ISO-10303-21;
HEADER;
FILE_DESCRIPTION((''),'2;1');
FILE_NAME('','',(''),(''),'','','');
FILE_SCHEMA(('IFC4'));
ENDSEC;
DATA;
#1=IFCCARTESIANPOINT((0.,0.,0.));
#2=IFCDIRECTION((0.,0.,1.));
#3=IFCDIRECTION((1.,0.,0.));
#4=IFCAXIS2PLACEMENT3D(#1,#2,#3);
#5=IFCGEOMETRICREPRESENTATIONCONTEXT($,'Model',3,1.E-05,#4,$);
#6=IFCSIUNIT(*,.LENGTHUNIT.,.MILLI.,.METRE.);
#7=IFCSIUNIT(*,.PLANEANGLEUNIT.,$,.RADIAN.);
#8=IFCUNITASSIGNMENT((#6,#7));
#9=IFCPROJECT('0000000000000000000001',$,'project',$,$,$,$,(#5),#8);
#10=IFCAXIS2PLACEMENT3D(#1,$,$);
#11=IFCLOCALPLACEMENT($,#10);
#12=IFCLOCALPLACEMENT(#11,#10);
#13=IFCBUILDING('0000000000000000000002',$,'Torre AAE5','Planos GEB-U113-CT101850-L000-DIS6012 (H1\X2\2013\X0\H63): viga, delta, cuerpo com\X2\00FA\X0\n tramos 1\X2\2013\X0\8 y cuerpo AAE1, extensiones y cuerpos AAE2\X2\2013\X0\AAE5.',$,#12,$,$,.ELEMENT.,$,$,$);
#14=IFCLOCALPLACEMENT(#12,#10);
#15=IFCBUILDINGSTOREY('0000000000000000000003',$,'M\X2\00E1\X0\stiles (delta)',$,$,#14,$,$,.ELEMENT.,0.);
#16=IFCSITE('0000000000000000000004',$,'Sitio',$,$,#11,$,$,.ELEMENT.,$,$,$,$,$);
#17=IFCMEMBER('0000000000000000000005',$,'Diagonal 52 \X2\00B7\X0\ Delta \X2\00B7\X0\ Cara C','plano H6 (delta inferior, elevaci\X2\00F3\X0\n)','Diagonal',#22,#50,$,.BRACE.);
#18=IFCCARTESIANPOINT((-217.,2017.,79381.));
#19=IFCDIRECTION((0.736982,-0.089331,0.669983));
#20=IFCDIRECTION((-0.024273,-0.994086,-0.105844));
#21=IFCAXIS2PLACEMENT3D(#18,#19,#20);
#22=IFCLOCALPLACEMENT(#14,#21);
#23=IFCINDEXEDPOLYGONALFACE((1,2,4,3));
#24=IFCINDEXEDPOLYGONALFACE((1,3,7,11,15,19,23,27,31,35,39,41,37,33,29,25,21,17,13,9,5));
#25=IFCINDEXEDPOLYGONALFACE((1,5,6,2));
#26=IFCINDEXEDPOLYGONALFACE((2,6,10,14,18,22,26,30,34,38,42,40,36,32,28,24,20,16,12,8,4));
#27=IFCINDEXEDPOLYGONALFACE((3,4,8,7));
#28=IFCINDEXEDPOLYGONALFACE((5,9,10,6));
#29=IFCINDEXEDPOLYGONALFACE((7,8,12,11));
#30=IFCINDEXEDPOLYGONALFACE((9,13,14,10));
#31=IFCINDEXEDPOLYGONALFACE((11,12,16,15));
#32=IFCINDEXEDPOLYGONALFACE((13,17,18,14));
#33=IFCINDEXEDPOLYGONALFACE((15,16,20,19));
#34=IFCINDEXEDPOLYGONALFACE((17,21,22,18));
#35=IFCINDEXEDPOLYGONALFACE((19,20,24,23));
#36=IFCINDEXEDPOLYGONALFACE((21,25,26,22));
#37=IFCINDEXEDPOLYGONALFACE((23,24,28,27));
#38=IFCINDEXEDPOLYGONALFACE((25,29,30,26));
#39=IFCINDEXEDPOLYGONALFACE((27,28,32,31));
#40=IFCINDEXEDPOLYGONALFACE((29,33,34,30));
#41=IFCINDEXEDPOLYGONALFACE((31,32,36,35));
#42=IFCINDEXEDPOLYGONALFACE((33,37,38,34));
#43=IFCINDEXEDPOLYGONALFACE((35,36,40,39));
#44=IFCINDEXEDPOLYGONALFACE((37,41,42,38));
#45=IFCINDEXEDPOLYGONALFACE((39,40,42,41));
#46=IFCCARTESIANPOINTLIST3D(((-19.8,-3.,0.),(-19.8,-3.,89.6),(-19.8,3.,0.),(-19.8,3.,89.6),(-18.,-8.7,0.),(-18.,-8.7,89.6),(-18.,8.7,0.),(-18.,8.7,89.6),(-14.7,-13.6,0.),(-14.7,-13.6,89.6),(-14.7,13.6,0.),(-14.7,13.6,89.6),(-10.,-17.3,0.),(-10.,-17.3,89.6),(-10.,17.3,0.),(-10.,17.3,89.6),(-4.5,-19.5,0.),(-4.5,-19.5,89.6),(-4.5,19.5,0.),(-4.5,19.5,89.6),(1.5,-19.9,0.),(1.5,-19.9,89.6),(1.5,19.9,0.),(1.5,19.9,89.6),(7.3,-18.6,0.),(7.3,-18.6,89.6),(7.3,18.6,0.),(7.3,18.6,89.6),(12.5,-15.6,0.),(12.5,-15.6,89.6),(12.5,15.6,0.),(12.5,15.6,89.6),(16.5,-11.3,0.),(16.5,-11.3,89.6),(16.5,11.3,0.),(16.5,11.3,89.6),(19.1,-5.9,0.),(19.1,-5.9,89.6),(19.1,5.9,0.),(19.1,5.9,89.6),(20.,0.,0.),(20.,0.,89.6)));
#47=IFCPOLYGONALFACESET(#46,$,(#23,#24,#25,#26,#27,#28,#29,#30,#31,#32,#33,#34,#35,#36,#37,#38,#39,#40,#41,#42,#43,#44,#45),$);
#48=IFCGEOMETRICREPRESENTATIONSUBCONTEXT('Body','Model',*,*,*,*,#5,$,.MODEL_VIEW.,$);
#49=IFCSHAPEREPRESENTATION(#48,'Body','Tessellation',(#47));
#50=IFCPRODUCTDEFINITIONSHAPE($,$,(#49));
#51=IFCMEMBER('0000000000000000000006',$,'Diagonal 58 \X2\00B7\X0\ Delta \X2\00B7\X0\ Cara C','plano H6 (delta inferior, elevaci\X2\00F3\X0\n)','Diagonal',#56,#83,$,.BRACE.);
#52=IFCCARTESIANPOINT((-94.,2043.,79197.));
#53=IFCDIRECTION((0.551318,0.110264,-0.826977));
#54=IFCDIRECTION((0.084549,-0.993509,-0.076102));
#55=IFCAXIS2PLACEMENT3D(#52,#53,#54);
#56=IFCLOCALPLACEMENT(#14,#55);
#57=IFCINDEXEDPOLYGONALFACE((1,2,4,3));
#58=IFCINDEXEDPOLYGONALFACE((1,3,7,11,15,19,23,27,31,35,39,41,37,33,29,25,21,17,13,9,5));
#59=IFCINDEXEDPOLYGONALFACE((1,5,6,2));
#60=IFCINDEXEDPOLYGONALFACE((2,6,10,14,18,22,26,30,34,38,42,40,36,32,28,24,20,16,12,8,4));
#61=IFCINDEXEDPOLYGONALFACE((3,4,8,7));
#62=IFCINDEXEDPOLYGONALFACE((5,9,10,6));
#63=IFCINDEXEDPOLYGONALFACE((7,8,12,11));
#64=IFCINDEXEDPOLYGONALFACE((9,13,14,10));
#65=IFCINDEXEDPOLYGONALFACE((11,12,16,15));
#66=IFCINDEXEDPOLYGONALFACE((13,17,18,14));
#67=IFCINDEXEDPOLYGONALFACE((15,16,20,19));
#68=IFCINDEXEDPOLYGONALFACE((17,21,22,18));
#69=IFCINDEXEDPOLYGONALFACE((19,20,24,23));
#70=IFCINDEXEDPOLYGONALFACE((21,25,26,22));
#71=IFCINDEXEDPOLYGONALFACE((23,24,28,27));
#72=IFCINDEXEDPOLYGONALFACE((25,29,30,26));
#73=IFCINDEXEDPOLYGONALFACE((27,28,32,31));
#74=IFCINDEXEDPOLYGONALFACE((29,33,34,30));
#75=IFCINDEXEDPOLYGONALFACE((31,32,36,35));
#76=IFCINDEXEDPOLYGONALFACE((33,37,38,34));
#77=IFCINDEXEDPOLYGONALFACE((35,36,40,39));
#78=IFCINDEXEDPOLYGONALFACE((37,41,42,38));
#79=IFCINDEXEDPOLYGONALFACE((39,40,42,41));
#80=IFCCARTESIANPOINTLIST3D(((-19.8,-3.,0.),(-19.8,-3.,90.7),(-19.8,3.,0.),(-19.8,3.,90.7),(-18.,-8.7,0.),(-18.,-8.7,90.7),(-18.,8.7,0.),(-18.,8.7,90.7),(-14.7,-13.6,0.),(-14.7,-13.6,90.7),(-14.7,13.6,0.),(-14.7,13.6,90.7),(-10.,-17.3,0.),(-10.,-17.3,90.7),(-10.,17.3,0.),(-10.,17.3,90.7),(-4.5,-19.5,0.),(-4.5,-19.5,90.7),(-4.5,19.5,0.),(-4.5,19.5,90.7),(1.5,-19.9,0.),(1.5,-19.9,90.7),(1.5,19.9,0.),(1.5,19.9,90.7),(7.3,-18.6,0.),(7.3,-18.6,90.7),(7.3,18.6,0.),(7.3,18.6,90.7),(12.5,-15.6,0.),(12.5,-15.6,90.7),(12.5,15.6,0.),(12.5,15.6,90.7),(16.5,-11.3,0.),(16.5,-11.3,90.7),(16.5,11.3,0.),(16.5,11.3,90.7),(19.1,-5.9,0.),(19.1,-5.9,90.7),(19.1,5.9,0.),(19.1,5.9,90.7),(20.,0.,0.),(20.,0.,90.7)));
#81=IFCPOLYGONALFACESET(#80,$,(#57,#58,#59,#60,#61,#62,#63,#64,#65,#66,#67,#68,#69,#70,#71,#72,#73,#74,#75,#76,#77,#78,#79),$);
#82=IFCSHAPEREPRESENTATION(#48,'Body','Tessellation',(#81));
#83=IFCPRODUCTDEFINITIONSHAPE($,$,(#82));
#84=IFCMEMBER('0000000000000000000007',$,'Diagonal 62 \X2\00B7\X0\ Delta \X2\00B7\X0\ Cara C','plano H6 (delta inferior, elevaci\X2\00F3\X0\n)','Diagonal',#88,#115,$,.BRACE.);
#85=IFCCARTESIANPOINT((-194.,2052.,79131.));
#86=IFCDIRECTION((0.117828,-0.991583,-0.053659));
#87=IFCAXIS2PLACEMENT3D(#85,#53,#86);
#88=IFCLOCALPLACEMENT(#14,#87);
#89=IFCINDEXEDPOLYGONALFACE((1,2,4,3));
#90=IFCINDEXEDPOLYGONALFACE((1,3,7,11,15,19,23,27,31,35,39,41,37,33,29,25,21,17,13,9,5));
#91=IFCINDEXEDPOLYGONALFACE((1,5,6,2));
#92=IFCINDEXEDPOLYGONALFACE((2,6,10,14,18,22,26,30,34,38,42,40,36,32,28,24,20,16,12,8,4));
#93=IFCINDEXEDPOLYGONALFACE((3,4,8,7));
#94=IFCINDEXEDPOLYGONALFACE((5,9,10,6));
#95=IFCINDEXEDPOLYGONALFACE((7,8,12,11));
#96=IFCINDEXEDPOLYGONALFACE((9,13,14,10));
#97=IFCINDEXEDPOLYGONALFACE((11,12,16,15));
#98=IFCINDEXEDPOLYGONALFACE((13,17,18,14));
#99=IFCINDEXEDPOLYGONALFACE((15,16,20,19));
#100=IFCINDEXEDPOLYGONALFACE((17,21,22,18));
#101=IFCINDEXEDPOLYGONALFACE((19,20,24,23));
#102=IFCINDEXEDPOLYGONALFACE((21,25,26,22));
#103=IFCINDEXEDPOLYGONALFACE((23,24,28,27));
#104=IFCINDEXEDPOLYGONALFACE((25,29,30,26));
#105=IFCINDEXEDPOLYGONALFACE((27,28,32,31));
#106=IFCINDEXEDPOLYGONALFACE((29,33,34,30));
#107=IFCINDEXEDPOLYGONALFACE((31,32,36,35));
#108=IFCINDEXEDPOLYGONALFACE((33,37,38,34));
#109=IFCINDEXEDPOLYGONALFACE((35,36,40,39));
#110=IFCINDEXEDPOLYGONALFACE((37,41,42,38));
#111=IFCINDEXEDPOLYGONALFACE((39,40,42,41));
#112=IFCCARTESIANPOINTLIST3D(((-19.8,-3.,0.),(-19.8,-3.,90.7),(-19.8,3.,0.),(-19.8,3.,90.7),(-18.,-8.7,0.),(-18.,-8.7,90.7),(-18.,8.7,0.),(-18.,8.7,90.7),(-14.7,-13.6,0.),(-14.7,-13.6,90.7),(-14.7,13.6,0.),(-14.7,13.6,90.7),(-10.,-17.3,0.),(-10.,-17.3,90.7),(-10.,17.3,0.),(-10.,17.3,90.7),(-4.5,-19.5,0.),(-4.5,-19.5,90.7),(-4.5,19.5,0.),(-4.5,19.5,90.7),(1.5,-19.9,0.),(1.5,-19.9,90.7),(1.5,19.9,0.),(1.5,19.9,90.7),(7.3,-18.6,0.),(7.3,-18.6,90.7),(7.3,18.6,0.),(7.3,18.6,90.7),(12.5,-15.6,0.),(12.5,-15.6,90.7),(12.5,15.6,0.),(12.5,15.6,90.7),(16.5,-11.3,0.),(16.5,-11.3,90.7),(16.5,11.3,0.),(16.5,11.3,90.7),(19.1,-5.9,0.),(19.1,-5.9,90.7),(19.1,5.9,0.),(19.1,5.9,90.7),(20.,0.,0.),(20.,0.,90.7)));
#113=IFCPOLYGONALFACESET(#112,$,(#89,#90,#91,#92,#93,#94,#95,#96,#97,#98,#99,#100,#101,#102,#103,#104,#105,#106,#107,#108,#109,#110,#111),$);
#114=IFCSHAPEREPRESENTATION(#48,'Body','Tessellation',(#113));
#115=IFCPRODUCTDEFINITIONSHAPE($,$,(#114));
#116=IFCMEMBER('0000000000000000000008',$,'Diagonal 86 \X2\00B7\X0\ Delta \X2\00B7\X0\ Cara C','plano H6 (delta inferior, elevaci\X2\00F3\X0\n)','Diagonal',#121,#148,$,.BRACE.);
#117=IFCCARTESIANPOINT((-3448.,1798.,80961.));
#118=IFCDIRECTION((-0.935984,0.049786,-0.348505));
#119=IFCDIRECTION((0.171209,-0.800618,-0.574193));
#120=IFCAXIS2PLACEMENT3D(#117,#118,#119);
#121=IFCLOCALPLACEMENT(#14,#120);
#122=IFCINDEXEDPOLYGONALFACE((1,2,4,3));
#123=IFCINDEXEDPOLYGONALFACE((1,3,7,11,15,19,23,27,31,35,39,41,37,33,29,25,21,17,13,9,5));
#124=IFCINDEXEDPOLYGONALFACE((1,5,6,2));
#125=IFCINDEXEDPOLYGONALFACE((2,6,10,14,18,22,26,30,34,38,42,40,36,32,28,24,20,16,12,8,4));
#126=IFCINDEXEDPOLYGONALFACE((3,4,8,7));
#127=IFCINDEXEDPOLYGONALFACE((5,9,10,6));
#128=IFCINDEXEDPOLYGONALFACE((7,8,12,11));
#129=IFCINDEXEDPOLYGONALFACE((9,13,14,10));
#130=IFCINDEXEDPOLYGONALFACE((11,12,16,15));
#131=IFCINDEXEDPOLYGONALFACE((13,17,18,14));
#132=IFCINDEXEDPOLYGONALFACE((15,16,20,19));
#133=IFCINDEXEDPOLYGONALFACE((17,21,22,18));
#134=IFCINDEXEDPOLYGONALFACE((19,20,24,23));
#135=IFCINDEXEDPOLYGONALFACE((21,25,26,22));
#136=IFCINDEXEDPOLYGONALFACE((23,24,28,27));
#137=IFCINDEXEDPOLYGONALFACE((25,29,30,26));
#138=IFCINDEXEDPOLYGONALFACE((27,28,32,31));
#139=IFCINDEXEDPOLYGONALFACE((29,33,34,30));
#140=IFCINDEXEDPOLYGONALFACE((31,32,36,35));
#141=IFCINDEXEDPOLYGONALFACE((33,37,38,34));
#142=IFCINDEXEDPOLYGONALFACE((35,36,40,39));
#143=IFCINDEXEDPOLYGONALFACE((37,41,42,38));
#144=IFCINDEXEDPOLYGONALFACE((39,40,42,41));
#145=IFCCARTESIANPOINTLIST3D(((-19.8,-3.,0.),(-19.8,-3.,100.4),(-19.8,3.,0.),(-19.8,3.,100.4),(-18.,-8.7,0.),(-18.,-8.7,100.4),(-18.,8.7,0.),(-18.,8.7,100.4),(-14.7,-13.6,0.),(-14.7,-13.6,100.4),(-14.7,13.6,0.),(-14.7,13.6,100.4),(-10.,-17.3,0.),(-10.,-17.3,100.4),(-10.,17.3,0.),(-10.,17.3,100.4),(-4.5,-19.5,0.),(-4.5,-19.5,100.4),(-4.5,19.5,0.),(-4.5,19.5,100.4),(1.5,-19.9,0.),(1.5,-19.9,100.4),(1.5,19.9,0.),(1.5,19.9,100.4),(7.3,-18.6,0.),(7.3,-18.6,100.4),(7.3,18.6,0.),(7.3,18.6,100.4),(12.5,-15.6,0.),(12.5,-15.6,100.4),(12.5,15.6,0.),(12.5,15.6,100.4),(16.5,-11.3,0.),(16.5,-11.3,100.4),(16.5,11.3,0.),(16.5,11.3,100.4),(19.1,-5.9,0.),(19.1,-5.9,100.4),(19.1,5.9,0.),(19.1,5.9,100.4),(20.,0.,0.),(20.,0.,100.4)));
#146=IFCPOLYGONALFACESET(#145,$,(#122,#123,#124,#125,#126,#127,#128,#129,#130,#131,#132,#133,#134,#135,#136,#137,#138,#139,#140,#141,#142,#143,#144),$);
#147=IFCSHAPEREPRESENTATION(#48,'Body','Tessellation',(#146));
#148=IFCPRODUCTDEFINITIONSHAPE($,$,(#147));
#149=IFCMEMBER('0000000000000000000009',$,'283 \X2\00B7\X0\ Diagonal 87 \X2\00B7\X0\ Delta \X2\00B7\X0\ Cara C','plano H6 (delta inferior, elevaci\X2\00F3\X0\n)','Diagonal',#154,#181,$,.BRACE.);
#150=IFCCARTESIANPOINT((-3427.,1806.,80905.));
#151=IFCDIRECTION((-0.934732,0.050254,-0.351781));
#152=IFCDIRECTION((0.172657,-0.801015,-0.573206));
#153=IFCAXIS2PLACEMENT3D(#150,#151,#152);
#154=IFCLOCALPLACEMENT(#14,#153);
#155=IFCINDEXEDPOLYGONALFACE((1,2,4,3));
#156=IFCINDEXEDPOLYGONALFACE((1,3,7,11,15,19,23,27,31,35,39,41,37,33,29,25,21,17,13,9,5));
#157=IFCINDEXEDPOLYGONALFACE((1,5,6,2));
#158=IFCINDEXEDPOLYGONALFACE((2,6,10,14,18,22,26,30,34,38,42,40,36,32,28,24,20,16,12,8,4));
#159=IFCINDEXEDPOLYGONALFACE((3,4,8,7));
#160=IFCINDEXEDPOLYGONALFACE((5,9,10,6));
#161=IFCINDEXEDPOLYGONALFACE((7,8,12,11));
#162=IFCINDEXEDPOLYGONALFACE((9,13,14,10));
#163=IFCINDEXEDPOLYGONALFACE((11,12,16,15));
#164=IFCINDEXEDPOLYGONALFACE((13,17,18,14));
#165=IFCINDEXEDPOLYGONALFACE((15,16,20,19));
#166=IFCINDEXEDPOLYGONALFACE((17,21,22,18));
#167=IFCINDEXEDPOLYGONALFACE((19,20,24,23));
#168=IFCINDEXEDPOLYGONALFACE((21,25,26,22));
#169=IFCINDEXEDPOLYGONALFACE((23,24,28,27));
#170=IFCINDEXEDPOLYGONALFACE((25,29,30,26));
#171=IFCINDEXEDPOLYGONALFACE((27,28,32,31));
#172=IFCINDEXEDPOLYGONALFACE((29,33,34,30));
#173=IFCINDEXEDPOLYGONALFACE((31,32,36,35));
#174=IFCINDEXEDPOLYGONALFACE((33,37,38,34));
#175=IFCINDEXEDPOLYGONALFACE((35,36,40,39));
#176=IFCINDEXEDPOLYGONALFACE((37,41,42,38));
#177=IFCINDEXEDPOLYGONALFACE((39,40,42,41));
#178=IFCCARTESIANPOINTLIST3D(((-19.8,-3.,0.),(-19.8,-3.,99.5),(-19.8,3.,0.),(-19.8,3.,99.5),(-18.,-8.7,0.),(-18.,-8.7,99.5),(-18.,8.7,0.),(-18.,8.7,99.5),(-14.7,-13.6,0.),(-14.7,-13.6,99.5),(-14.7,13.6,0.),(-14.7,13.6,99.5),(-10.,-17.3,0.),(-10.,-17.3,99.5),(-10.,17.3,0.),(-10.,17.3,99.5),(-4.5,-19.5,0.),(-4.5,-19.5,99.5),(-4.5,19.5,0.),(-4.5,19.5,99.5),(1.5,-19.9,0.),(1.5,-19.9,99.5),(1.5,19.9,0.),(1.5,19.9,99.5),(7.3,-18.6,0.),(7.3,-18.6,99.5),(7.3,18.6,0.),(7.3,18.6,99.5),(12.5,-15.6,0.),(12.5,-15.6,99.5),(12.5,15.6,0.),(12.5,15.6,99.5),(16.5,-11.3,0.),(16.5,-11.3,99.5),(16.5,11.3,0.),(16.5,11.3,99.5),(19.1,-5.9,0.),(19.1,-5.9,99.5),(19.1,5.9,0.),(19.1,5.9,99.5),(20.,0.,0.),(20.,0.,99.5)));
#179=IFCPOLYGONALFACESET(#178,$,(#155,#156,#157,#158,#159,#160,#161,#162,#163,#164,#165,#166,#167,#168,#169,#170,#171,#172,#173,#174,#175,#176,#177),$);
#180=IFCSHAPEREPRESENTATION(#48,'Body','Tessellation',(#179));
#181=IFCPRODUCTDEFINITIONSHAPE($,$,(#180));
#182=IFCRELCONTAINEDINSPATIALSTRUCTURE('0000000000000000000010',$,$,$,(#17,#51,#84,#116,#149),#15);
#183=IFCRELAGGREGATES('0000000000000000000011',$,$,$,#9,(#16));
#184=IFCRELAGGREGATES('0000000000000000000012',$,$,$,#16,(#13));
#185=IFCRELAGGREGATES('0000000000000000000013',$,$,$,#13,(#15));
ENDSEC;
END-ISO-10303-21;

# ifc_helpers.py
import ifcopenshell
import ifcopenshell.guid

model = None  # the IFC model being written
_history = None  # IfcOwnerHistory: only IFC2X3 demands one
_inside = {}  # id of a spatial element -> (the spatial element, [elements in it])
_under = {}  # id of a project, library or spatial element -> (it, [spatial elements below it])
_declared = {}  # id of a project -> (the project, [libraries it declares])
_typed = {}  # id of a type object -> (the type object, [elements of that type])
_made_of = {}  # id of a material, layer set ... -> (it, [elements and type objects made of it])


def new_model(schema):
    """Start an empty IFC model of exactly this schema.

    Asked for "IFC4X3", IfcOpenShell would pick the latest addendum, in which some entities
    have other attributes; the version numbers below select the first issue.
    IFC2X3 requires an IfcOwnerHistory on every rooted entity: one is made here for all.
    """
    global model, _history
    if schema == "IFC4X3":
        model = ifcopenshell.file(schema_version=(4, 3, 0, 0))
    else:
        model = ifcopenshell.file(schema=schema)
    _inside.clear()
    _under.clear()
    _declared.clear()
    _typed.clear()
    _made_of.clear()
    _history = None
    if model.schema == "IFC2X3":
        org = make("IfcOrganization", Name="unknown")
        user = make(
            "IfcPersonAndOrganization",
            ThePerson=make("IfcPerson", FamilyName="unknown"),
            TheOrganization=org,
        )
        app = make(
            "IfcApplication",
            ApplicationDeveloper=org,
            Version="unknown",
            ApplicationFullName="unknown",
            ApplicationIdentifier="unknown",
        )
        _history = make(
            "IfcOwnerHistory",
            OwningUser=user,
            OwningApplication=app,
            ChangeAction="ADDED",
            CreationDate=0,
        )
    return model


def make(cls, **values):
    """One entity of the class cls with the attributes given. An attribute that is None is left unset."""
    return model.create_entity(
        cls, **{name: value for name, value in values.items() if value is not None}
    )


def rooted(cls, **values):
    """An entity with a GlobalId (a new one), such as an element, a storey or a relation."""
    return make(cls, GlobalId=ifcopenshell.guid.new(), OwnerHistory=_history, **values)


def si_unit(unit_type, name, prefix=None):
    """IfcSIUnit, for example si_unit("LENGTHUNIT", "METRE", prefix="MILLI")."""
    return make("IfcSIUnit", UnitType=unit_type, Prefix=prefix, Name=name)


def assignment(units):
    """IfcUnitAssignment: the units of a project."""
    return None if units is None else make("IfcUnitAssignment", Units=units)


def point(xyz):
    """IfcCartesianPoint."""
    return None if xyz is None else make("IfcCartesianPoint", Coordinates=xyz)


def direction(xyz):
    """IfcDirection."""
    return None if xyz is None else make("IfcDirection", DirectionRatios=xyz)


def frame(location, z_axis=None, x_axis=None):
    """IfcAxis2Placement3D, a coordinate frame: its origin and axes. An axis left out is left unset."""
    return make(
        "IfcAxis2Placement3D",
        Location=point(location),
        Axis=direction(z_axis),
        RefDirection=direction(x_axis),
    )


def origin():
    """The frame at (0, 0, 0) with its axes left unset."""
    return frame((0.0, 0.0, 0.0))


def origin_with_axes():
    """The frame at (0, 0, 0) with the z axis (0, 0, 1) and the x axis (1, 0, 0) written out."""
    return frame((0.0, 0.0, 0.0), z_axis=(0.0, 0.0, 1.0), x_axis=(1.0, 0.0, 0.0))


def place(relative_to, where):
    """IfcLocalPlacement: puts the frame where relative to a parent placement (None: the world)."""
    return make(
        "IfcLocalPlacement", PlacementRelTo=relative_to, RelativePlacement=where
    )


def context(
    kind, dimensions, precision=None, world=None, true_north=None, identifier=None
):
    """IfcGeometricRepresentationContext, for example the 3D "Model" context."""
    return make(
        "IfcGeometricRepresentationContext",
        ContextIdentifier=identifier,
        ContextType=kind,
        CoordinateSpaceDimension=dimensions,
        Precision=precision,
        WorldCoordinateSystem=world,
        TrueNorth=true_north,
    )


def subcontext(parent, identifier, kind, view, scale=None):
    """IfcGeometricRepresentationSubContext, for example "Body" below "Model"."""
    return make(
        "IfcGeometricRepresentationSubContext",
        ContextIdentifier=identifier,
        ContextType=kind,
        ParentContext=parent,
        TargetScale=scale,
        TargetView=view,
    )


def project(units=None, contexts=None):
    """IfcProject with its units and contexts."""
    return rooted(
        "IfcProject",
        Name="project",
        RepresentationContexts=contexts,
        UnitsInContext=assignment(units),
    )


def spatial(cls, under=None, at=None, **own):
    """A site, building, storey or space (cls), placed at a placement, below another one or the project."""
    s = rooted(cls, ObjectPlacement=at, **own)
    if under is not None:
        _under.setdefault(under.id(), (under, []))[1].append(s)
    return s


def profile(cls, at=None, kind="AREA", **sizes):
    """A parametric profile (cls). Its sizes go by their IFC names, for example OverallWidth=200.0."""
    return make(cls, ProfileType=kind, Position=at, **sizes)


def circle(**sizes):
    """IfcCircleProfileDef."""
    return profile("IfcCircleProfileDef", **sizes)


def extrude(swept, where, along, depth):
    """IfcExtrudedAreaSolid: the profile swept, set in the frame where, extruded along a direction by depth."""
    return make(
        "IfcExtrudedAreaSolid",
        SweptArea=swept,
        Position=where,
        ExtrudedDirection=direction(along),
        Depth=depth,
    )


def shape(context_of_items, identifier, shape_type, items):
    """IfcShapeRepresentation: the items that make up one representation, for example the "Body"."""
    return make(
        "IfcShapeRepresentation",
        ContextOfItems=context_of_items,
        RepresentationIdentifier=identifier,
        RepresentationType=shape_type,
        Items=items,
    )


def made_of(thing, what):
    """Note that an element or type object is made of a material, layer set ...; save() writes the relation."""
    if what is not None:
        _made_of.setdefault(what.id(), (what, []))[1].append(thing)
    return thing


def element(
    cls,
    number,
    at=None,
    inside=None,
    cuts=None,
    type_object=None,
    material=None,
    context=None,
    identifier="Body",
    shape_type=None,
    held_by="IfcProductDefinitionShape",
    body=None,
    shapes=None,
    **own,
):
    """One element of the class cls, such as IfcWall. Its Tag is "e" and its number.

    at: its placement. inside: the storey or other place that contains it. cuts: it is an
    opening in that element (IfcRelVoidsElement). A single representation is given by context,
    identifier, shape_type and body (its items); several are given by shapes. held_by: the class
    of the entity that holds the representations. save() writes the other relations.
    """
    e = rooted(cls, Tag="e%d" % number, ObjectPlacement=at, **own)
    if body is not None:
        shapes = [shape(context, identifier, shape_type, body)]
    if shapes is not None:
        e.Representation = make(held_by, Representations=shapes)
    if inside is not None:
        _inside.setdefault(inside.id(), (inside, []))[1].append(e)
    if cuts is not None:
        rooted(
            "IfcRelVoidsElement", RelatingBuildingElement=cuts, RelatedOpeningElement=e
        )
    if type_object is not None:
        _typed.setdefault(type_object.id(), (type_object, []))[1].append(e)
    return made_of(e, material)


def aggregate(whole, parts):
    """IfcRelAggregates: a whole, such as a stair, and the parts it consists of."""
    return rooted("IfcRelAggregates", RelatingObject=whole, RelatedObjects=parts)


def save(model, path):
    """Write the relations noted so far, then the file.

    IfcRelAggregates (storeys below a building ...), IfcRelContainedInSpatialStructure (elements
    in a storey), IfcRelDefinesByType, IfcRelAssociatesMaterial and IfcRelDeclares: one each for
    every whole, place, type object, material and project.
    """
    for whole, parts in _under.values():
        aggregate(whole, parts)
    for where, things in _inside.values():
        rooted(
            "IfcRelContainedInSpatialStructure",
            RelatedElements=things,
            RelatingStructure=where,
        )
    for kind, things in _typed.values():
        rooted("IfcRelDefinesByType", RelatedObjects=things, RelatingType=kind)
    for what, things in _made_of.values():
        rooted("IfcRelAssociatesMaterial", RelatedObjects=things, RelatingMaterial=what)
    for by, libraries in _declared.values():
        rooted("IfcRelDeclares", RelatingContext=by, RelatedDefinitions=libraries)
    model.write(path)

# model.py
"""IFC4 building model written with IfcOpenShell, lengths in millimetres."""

from ifc_helpers import new_model, si_unit, frame, origin, origin_with_axes, place, context, subcontext, project, spatial, circle, extrude, element, save


model = new_model("IFC4")

# Units and contexts
model_context = context("Model", 3, precision=1e-05, world=origin_with_axes())
body_context = subcontext(model_context, "Body", "Model", "MODEL_VIEW")
ifc_project = project(units=[si_unit("LENGTHUNIT", "METRE", prefix="MILLI"), si_unit("PLANEANGLEUNIT", "RADIAN")], contexts=[model_context])

# Site, building, storey
site_placement = place(None, origin())
site = spatial("IfcSite", under=ifc_project, at=site_placement, Name="Sitio", CompositionType="ELEMENT")
building_placement = place(site_placement, origin())
building = spatial("IfcBuilding", under=site, at=building_placement, Name="Torre AAE5", Description="Planos GEB-U113-CT101850-L000-DIS6012 (H1–H63): viga, delta, cuerpo común tramos 1–8 y cuerpo AAE1, extensiones y cuerpos AAE2–AAE5.", CompositionType="ELEMENT")
storey_placement = place(building_placement, origin())
storey = spatial("IfcBuildingStorey", under=building, at=storey_placement, Name="Mástiles (delta)", CompositionType="ELEMENT", Elevation=0.0)

# Members
member_1_placement = place(storey_placement, frame((-217.0, 2017.0, 79381.0), z_axis=(0.736982, -0.089331, 0.669983), x_axis=(-0.024273, -0.994086, -0.105844)))
element("IfcMember", 1, at=member_1_placement, inside=storey, Name="Diagonal 52 · Delta · Cara C", Description="plano H6 (delta inferior, elevación)", ObjectType="Diagonal", PredefinedType="BRACE", context=body_context, shape_type="SweptSolid", body=[
    extrude(circle(Radius=20.0), None, (0.0, 0.0, 1.0), 89.6),
])
member_2_placement = place(storey_placement, frame((-94.0, 2043.0, 79197.0), z_axis=(0.551318, 0.110264, -0.826977), x_axis=(0.084549, -0.993509, -0.076102)))
element("IfcMember", 2, at=member_2_placement, inside=storey, Name="Diagonal 58 · Delta · Cara C", Description="plano H6 (delta inferior, elevación)", ObjectType="Diagonal", PredefinedType="BRACE", context=body_context, shape_type="SweptSolid", body=[
    extrude(circle(Radius=20.0), None, (0.0, 0.0, 1.0), 90.7),
])
member_3_placement = place(storey_placement, frame((-194.0, 2052.0, 79131.0), z_axis=(0.551318, 0.110264, -0.826977), x_axis=(0.117828, -0.991583, -0.053659)))
element("IfcMember", 3, at=member_3_placement, inside=storey, Name="Diagonal 62 · Delta · Cara C", Description="plano H6 (delta inferior, elevación)", ObjectType="Diagonal", PredefinedType="BRACE", context=body_context, shape_type="SweptSolid", body=[
    extrude(circle(Radius=20.0), None, (0.0, 0.0, 1.0), 90.7),
])
member_4_placement = place(storey_placement, frame((-3448.0, 1798.0, 80961.0), z_axis=(-0.935984, 0.049786, -0.348505), x_axis=(0.171209, -0.800618, -0.574193)))
element("IfcMember", 4, at=member_4_placement, inside=storey, Name="Diagonal 86 · Delta · Cara C", Description="plano H6 (delta inferior, elevación)", ObjectType="Diagonal", PredefinedType="BRACE", context=body_context, shape_type="SweptSolid", body=[
    extrude(circle(Radius=20.0), None, (0.0, 0.0, 1.0), 100.4),
])
member_5_placement = place(storey_placement, frame((-3427.0, 1806.0, 80905.0), z_axis=(-0.934732, 0.050254, -0.351781), x_axis=(0.172657, -0.801015, -0.573206)))
element("IfcMember", 5, at=member_5_placement, inside=storey, Name="283 · Diagonal 87 · Delta · Cara C", Description="plano H6 (delta inferior, elevación)", ObjectType="Diagonal", PredefinedType="BRACE", context=body_context, shape_type="SweptSolid", body=[
    extrude(circle(Radius=20.0), None, (0.0, 0.0, 1.0), 99.5),
])

save(model, "model.ifc")
